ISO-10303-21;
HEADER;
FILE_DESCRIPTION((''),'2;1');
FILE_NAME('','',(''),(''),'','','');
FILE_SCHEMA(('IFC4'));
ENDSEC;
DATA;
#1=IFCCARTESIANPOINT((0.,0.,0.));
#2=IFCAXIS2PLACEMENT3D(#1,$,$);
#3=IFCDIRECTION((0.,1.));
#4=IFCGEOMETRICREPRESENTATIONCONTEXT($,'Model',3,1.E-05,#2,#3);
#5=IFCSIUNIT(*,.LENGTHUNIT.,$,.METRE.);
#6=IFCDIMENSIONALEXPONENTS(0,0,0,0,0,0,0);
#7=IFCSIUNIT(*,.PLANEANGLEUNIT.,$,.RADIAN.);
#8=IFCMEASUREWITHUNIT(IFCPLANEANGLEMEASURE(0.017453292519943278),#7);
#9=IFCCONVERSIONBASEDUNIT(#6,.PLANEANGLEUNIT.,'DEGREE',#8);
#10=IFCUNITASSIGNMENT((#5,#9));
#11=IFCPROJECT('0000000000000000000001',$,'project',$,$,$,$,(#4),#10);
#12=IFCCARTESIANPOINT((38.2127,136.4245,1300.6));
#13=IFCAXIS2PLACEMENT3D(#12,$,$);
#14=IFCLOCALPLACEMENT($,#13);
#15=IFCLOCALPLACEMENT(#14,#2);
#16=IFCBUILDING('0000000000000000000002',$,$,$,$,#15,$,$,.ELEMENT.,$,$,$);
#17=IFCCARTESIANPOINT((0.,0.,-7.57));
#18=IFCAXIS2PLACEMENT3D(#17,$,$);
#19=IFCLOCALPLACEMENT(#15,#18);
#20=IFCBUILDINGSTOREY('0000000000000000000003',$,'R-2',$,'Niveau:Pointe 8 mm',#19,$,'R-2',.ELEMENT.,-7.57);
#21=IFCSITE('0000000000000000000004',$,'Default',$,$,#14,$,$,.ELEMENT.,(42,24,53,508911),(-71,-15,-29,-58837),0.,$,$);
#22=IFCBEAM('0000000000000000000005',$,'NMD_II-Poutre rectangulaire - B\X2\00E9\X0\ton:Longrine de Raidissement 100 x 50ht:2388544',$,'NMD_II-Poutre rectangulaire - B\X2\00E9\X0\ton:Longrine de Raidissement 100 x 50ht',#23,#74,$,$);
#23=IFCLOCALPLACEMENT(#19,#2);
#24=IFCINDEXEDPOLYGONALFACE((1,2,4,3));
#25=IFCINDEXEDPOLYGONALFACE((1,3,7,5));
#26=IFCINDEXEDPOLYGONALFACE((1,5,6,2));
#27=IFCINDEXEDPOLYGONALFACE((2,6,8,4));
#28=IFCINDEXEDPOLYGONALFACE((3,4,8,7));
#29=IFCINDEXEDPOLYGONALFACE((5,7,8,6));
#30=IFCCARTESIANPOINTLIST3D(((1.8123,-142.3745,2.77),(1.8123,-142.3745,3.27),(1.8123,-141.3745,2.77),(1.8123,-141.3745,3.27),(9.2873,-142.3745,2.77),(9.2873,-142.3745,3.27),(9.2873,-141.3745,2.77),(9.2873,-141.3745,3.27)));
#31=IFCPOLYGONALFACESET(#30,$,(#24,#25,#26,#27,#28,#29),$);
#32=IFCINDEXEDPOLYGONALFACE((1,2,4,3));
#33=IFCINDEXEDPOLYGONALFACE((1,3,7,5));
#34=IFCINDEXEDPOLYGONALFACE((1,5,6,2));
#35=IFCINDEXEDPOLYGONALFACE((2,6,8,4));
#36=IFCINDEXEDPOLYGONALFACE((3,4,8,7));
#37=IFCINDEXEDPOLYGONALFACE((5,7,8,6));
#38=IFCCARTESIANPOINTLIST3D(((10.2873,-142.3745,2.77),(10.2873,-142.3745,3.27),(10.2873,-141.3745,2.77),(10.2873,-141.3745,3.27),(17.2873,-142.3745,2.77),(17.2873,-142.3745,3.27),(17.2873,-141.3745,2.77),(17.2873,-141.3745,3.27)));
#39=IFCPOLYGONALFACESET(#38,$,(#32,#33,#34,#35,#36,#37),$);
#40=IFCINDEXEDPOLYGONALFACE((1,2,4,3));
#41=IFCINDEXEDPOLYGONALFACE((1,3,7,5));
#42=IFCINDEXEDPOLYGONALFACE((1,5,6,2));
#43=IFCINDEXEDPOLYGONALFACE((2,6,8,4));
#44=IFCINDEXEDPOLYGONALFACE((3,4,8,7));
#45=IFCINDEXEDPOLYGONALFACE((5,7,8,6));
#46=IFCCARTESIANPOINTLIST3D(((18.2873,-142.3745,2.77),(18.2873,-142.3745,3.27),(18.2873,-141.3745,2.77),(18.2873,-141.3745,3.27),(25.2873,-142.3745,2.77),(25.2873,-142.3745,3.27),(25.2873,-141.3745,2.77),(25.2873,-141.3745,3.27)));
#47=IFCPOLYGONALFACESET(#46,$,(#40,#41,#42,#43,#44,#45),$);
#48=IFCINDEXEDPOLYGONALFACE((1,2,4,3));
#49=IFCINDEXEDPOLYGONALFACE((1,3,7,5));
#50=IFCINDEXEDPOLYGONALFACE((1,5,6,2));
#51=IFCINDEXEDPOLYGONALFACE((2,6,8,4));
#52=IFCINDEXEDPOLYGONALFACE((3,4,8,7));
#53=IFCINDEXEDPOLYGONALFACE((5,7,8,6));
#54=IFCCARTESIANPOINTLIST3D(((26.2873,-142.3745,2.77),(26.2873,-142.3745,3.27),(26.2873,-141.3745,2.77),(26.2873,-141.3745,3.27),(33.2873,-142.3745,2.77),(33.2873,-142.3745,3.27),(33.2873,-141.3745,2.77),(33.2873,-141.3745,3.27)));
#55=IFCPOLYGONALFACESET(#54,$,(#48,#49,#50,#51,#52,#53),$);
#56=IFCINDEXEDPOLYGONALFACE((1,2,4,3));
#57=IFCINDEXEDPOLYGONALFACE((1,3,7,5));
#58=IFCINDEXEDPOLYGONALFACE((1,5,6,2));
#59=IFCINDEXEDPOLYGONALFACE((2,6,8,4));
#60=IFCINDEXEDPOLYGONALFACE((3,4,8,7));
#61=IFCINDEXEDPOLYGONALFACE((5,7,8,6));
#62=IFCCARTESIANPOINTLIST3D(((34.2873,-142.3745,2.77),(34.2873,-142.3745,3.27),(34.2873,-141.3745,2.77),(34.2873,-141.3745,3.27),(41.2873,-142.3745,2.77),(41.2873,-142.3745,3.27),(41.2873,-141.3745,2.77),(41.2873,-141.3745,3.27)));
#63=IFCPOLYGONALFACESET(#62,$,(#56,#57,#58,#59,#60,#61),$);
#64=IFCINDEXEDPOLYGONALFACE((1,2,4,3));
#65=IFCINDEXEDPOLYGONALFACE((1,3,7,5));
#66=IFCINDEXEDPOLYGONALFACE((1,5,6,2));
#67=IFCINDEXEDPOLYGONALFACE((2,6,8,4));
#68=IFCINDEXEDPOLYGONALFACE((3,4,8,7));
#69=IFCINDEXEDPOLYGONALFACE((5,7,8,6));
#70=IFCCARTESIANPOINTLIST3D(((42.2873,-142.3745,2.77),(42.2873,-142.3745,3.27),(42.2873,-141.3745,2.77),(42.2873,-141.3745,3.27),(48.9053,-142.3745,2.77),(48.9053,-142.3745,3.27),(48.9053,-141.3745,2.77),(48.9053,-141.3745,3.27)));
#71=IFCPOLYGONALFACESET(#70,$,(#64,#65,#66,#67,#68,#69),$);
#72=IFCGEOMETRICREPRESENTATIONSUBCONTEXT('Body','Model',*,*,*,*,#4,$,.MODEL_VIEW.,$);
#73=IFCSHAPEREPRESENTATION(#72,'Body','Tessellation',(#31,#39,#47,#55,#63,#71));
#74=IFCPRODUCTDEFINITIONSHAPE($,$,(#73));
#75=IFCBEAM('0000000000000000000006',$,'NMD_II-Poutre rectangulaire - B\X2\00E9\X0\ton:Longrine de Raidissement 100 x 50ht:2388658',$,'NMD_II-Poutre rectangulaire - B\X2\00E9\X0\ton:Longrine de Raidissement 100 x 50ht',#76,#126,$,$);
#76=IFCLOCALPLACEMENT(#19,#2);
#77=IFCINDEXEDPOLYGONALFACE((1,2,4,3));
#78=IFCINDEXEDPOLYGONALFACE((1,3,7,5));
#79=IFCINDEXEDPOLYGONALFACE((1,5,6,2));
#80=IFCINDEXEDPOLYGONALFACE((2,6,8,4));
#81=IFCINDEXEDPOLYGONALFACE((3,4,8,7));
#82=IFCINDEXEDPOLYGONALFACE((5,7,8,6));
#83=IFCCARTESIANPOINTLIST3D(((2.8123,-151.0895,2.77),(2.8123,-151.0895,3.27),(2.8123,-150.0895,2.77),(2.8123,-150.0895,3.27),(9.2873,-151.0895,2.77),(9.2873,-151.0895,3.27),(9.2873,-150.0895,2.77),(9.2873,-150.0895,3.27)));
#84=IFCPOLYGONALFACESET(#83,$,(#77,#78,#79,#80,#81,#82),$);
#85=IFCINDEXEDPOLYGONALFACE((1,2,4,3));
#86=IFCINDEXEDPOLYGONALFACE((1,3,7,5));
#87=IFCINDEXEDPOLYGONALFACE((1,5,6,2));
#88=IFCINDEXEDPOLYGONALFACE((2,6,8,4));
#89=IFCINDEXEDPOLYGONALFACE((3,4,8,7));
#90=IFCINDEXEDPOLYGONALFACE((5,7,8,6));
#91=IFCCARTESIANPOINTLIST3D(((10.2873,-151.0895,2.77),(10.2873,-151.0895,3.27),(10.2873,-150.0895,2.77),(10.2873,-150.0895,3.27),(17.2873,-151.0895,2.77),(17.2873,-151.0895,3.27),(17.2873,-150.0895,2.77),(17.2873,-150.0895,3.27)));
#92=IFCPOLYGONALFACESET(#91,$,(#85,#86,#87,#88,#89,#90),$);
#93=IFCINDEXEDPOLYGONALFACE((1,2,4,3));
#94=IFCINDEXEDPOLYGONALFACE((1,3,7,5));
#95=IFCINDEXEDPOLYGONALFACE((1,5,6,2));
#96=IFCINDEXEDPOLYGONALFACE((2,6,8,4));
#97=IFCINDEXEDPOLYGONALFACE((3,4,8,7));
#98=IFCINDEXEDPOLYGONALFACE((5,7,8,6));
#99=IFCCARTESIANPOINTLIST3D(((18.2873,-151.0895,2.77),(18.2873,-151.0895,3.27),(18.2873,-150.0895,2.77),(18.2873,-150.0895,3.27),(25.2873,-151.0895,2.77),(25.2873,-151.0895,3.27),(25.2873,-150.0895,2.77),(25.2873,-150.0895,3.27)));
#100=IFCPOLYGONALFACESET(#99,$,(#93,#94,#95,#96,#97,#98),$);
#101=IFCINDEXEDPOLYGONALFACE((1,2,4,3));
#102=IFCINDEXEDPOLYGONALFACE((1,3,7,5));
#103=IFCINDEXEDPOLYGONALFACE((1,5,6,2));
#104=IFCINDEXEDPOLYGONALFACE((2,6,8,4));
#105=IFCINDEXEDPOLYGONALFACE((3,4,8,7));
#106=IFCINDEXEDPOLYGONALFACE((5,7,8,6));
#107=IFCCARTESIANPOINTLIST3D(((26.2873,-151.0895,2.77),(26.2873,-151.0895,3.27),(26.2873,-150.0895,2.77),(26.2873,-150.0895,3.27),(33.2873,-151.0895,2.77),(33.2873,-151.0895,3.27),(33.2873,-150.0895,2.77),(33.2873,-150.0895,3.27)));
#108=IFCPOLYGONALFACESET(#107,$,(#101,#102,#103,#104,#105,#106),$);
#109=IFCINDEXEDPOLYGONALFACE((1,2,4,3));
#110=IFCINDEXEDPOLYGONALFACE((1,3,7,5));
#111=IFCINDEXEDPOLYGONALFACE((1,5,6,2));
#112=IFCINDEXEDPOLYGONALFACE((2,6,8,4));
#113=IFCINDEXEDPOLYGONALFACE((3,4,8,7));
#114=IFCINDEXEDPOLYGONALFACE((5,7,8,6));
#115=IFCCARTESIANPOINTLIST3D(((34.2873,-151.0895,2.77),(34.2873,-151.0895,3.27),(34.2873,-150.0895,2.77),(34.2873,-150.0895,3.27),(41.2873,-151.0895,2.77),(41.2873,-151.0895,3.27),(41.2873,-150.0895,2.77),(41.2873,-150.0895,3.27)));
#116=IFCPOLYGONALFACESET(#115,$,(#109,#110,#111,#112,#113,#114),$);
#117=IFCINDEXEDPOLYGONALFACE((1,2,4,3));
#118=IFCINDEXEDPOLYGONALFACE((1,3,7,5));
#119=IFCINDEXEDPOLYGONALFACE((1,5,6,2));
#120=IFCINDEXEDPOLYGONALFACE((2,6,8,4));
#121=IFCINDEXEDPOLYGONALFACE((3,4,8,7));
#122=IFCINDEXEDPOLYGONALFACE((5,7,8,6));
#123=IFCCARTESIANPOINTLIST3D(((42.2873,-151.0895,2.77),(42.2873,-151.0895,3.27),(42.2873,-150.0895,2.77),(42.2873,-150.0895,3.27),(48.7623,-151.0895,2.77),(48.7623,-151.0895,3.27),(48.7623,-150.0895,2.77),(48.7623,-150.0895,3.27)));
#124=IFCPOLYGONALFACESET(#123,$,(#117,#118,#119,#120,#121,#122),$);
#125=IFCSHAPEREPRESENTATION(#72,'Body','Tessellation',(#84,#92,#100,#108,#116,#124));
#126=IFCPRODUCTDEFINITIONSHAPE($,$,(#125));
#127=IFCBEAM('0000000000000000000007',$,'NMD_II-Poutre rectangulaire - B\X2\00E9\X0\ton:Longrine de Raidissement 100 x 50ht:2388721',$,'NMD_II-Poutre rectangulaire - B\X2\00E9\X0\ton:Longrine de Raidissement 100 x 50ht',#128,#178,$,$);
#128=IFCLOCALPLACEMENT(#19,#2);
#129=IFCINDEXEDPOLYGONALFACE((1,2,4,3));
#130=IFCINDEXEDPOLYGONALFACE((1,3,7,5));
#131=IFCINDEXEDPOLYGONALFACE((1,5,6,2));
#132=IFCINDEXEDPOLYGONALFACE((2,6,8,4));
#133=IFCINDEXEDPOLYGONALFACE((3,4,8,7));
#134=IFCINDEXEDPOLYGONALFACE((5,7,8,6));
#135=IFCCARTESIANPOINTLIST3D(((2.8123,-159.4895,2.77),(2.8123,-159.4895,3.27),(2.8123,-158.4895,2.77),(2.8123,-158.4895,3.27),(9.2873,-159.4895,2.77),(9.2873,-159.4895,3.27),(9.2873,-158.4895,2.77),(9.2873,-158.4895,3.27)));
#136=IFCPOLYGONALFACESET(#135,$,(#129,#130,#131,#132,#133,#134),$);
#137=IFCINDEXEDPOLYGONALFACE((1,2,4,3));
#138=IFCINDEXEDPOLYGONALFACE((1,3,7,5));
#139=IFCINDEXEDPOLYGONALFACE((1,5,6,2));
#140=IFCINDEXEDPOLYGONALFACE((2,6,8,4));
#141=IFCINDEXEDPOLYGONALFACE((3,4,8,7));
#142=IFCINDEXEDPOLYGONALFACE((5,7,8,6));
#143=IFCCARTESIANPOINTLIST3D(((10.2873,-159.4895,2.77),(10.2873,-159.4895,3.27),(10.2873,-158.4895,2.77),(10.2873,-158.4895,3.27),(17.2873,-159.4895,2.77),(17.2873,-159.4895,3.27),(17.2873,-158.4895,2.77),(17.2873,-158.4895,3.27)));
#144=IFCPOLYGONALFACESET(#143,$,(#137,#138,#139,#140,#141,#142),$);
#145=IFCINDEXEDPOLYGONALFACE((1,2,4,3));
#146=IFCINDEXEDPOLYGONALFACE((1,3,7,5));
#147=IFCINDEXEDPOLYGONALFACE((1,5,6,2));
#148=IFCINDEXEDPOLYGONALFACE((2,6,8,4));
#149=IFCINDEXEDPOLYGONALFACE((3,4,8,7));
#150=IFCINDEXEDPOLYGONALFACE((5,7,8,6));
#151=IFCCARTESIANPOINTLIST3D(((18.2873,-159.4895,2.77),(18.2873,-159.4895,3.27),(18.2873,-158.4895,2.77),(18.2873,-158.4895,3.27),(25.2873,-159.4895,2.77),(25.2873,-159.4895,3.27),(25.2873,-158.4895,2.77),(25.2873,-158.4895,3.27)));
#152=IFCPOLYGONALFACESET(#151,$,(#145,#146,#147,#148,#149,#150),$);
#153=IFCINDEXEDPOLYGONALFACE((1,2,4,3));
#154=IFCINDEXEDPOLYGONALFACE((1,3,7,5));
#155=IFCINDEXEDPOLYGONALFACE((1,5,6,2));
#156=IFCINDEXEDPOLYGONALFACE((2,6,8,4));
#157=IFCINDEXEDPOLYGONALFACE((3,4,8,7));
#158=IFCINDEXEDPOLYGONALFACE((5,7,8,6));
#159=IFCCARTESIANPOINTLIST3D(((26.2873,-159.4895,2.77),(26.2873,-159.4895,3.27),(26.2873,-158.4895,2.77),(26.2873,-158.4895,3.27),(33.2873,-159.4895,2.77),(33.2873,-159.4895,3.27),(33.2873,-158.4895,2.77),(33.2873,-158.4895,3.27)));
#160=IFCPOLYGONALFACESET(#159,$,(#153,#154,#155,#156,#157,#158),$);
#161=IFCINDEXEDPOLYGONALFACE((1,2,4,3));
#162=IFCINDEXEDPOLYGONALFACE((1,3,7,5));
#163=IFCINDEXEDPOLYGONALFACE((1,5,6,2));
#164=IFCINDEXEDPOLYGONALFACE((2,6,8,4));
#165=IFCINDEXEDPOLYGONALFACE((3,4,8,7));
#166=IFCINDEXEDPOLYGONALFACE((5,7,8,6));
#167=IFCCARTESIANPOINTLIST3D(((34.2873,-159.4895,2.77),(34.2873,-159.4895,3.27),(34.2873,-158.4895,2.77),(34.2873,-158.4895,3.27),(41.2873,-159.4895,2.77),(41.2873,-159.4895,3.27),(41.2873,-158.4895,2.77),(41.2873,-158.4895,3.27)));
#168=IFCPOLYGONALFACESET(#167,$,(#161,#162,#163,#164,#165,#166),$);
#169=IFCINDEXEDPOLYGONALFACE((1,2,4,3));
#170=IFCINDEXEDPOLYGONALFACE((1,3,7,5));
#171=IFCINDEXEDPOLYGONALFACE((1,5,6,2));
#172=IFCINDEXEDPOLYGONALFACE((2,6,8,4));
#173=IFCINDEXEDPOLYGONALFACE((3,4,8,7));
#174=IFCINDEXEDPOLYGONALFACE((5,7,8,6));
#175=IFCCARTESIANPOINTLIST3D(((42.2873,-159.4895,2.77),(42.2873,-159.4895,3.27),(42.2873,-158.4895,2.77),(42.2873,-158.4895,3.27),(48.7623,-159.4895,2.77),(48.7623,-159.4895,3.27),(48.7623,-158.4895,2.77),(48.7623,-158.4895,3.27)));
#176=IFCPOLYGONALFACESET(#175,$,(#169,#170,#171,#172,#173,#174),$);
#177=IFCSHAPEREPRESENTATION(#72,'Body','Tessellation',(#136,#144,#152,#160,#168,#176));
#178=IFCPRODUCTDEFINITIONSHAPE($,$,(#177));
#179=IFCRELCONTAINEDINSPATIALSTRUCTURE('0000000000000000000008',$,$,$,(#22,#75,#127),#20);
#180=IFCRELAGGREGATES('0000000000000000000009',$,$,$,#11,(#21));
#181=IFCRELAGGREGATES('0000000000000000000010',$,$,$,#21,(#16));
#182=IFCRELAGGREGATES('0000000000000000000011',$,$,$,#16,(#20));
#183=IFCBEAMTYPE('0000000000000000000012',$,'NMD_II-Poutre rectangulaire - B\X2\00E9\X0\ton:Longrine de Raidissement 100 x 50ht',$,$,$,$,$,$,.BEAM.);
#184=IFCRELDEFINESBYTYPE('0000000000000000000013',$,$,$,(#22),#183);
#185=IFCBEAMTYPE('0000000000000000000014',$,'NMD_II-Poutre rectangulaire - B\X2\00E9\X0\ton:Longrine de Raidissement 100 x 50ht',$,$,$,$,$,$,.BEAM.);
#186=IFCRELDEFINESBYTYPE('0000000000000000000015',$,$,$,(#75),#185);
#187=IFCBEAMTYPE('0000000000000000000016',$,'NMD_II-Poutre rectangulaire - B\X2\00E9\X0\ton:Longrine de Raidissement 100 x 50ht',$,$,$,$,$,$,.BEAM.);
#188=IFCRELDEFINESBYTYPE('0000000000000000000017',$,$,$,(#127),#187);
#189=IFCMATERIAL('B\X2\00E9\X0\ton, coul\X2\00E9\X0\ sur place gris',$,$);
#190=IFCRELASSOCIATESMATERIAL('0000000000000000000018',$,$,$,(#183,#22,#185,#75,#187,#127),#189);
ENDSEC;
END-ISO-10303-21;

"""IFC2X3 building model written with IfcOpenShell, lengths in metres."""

from ifc_helpers import new_model, entity, si_unit, converted_unit, direction, frame, frame_2d, origin, place, context, subcontext, project, spatial, rectangle, extrude, source, transform, mapped, material, type_object, type_shapes, element, save


model = new_model("IFC2X3")

# Units and contexts
model_context = context("Model", 3, precision=1e-05, world=origin(), true_north=direction((0.0, 1.0)))
body_context = subcontext(model_context, "Body", "Model", "MODEL_VIEW")
ifc_project = project(units=[si_unit("LENGTHUNIT", "METRE"), converted_unit("PLANEANGLEUNIT", "DEGREE", entity("IfcPlaneAngleMeasure", 0.017453292519943278), si_unit("PLANEANGLEUNIT", "RADIAN"), dimensions=[0, 0, 0, 0, 0, 0, 0])], contexts=[model_context])

# Site, building, storey
site_placement = place(None, frame((38.2127, 136.4245, 1300.6)))
site = spatial("IfcSite", under=ifc_project, at=site_placement, Name="Default", CompositionType="ELEMENT", RefLatitude=(42, 24, 53, 508911), RefLongitude=(-71, -15, -29, -58837), RefElevation=0.0)
building_placement = place(site_placement, origin())
building = spatial("IfcBuilding", under=site, at=building_placement, CompositionType="ELEMENT")
storey_placement = place(building_placement, frame((0.0, 0.0, -7.57)))
storey = spatial("IfcBuildingStorey", under=building, at=storey_placement, Name="R-2", ObjectType="Niveau:Pointe 8 mm", LongName="R-2", CompositionType="ELEMENT", Elevation=-7.57)

# Beams
ifc_material_1 = material(Name="Béton, coulé sur place gris")
beam_type_1 = type_object("IfcBeamType", Name="NMD_II-Poutre rectangulaire - Béton:Longrine de Raidissement 100 x 50ht", PredefinedType="BEAM", material=ifc_material_1)
shared_shape_1 = source(origin(), body_context, "Body", "SweptSolid", [
    extrude(rectangle(XDim=0.5, YDim=1.0, at=frame_2d((0.0, 0.0), x_axis=(1.0, 0.0))), frame((9.2873, -141.8745, -4.55), z_axis=(-1.0, 0.0, 0.0), x_axis=(0.0, 0.0, -1.0)), (0.0, 0.0, 1.0), 7.475),
    extrude(rectangle(XDim=0.5, YDim=1.0, at=frame_2d((0.0, 0.0), x_axis=(1.0, 0.0))), frame((17.2873, -141.8745, -4.55), z_axis=(-1.0, 0.0, 0.0), x_axis=(0.0, 0.0, -1.0)), (0.0, 0.0, 1.0), 7.0),
    extrude(rectangle(XDim=0.5, YDim=1.0, at=frame_2d((0.0, 0.0), x_axis=(1.0, 0.0))), frame((25.2873, -141.8745, -4.55), z_axis=(-1.0, 0.0, 0.0), x_axis=(0.0, 0.0, -1.0)), (0.0, 0.0, 1.0), 7.0),
    extrude(rectangle(XDim=0.5, YDim=1.0, at=frame_2d((0.0, 0.0), x_axis=(1.0, 0.0))), frame((33.2873, -141.8745, -4.55), z_axis=(-1.0, 0.0, 0.0), x_axis=(0.0, 0.0, -1.0)), (0.0, 0.0, 1.0), 7.0),
    extrude(rectangle(XDim=0.5, YDim=1.0, at=frame_2d((0.0, 0.0), x_axis=(1.0, 0.0))), frame((41.2873, -141.8745, -4.55), z_axis=(-1.0, 0.0, 0.0), x_axis=(0.0, 0.0, -1.0)), (0.0, 0.0, 1.0), 7.0),
    extrude(rectangle(XDim=0.5, YDim=1.0, at=frame_2d((0.0, 0.0), x_axis=(1.0, 0.0))), frame((48.9053, -141.8745, -4.55), z_axis=(-1.0, 0.0, 0.0), x_axis=(0.0, 0.0, -1.0)), (0.0, 0.0, 1.0), 6.618),
])
type_shapes(beam_type_1, [shared_shape_1])
beam_1_placement = place(storey_placement, frame((0.0, 0.0, 7.57)))
element("IfcBeam", 1, at=beam_1_placement, inside=storey, type_object=beam_type_1, material=ifc_material_1, Name="NMD_II-Poutre rectangulaire - Béton:Longrine de Raidissement 100 x 50ht:2388544", ObjectType="NMD_II-Poutre rectangulaire - Béton:Longrine de Raidissement 100 x 50ht", context=body_context, shape_type="MappedRepresentation", body=[
    mapped(shared_shape_1, transform((0.0, 0.0, 0.0), scale=1.0)),
])
beam_type_2 = type_object("IfcBeamType", Name="NMD_II-Poutre rectangulaire - Béton:Longrine de Raidissement 100 x 50ht", PredefinedType="BEAM", material=ifc_material_1)
shared_shape_2 = source(origin(), body_context, "Body", "SweptSolid", [
    extrude(rectangle(XDim=0.5, YDim=1.0, at=frame_2d((0.0, 0.0), x_axis=(1.0, 0.0))), frame((9.2873, -150.5895, -4.55), z_axis=(-1.0, 0.0, 0.0), x_axis=(0.0, 0.0, -1.0)), (0.0, 0.0, 1.0), 6.475),
    extrude(rectangle(XDim=0.5, YDim=1.0, at=frame_2d((0.0, 0.0), x_axis=(1.0, 0.0))), frame((17.2873, -150.5895, -4.55), z_axis=(-1.0, 0.0, 0.0), x_axis=(0.0, 0.0, -1.0)), (0.0, 0.0, 1.0), 7.0),
    extrude(rectangle(XDim=0.5, YDim=1.0, at=frame_2d((0.0, 0.0), x_axis=(1.0, 0.0))), frame((25.2873, -150.5895, -4.55), z_axis=(-1.0, 0.0, 0.0), x_axis=(0.0, 0.0, -1.0)), (0.0, 0.0, 1.0), 7.0),
    extrude(rectangle(XDim=0.5, YDim=1.0, at=frame_2d((0.0, 0.0), x_axis=(1.0, 0.0))), frame((33.2873, -150.5895, -4.55), z_axis=(-1.0, 0.0, 0.0), x_axis=(0.0, 0.0, -1.0)), (0.0, 0.0, 1.0), 7.0),
    extrude(rectangle(XDim=0.5, YDim=1.0, at=frame_2d((0.0, 0.0), x_axis=(1.0, 0.0))), frame((41.2873, -150.5895, -4.55), z_axis=(-1.0, 0.0, 0.0), x_axis=(0.0, 0.0, -1.0)), (0.0, 0.0, 1.0), 7.0),
    extrude(rectangle(XDim=0.5, YDim=1.0, at=frame_2d((0.0, 0.0), x_axis=(1.0, 0.0))), frame((48.7623, -150.5895, -4.55), z_axis=(-1.0, 0.0, 0.0), x_axis=(0.0, 0.0, -1.0)), (0.0, 0.0, 1.0), 6.475),
])
type_shapes(beam_type_2, [shared_shape_2])
beam_2_placement = place(storey_placement, frame((0.0, 0.0, 7.57)))
element("IfcBeam", 2, at=beam_2_placement, inside=storey, type_object=beam_type_2, material=ifc_material_1, Name="NMD_II-Poutre rectangulaire - Béton:Longrine de Raidissement 100 x 50ht:2388658", ObjectType="NMD_II-Poutre rectangulaire - Béton:Longrine de Raidissement 100 x 50ht", context=body_context, shape_type="MappedRepresentation", body=[
    mapped(shared_shape_2, transform((0.0, 0.0, 0.0), scale=1.0)),
])
beam_type_3 = type_object("IfcBeamType", Name="NMD_II-Poutre rectangulaire - Béton:Longrine de Raidissement 100 x 50ht", PredefinedType="BEAM", material=ifc_material_1)
shared_shape_3 = source(origin(), body_context, "Body", "SweptSolid", [
    extrude(rectangle(XDim=0.5, YDim=1.0, at=frame_2d((0.0, 0.0), x_axis=(1.0, 0.0))), frame((9.2873, -158.9895, -4.55), z_axis=(-1.0, 0.0, 0.0), x_axis=(0.0, 0.0, -1.0)), (0.0, 0.0, 1.0), 6.475),
    extrude(rectangle(XDim=0.5, YDim=1.0, at=frame_2d((0.0, 0.0), x_axis=(1.0, 0.0))), frame((17.2873, -158.9895, -4.55), z_axis=(-1.0, 0.0, 0.0), x_axis=(0.0, 0.0, -1.0)), (0.0, 0.0, 1.0), 7.0),
    extrude(rectangle(XDim=0.5, YDim=1.0, at=frame_2d((0.0, 0.0), x_axis=(1.0, 0.0))), frame((25.2873, -158.9895, -4.55), z_axis=(-1.0, 0.0, 0.0), x_axis=(0.0, 0.0, -1.0)), (0.0, 0.0, 1.0), 7.0),
    extrude(rectangle(XDim=0.5, YDim=1.0, at=frame_2d((0.0, 0.0), x_axis=(1.0, 0.0))), frame((33.2873, -158.9895, -4.55), z_axis=(-1.0, 0.0, 0.0), x_axis=(0.0, 0.0, -1.0)), (0.0, 0.0, 1.0), 7.0),
    extrude(rectangle(XDim=0.5, YDim=1.0, at=frame_2d((0.0, 0.0), x_axis=(1.0, 0.0))), frame((41.2873, -158.9895, -4.55), z_axis=(-1.0, 0.0, 0.0), x_axis=(0.0, 0.0, -1.0)), (0.0, 0.0, 1.0), 7.0),
    extrude(rectangle(XDim=0.5, YDim=1.0, at=frame_2d((0.0, 0.0), x_axis=(1.0, 0.0))), frame((48.7623, -158.9895, -4.55), z_axis=(-1.0, 0.0, 0.0), x_axis=(0.0, 0.0, -1.0)), (0.0, 0.0, 1.0), 6.475),
])
type_shapes(beam_type_3, [shared_shape_3])
beam_3_placement = place(storey_placement, frame((0.0, 0.0, 7.57)))
element("IfcBeam", 3, at=beam_3_placement, inside=storey, type_object=beam_type_3, material=ifc_material_1, Name="NMD_II-Poutre rectangulaire - Béton:Longrine de Raidissement 100 x 50ht:2388721", ObjectType="NMD_II-Poutre rectangulaire - Béton:Longrine de Raidissement 100 x 50ht", context=body_context, shape_type="MappedRepresentation", body=[
    mapped(shared_shape_3, transform((0.0, 0.0, 0.0), scale=1.0)),
])

save(model, "model.ifc")
